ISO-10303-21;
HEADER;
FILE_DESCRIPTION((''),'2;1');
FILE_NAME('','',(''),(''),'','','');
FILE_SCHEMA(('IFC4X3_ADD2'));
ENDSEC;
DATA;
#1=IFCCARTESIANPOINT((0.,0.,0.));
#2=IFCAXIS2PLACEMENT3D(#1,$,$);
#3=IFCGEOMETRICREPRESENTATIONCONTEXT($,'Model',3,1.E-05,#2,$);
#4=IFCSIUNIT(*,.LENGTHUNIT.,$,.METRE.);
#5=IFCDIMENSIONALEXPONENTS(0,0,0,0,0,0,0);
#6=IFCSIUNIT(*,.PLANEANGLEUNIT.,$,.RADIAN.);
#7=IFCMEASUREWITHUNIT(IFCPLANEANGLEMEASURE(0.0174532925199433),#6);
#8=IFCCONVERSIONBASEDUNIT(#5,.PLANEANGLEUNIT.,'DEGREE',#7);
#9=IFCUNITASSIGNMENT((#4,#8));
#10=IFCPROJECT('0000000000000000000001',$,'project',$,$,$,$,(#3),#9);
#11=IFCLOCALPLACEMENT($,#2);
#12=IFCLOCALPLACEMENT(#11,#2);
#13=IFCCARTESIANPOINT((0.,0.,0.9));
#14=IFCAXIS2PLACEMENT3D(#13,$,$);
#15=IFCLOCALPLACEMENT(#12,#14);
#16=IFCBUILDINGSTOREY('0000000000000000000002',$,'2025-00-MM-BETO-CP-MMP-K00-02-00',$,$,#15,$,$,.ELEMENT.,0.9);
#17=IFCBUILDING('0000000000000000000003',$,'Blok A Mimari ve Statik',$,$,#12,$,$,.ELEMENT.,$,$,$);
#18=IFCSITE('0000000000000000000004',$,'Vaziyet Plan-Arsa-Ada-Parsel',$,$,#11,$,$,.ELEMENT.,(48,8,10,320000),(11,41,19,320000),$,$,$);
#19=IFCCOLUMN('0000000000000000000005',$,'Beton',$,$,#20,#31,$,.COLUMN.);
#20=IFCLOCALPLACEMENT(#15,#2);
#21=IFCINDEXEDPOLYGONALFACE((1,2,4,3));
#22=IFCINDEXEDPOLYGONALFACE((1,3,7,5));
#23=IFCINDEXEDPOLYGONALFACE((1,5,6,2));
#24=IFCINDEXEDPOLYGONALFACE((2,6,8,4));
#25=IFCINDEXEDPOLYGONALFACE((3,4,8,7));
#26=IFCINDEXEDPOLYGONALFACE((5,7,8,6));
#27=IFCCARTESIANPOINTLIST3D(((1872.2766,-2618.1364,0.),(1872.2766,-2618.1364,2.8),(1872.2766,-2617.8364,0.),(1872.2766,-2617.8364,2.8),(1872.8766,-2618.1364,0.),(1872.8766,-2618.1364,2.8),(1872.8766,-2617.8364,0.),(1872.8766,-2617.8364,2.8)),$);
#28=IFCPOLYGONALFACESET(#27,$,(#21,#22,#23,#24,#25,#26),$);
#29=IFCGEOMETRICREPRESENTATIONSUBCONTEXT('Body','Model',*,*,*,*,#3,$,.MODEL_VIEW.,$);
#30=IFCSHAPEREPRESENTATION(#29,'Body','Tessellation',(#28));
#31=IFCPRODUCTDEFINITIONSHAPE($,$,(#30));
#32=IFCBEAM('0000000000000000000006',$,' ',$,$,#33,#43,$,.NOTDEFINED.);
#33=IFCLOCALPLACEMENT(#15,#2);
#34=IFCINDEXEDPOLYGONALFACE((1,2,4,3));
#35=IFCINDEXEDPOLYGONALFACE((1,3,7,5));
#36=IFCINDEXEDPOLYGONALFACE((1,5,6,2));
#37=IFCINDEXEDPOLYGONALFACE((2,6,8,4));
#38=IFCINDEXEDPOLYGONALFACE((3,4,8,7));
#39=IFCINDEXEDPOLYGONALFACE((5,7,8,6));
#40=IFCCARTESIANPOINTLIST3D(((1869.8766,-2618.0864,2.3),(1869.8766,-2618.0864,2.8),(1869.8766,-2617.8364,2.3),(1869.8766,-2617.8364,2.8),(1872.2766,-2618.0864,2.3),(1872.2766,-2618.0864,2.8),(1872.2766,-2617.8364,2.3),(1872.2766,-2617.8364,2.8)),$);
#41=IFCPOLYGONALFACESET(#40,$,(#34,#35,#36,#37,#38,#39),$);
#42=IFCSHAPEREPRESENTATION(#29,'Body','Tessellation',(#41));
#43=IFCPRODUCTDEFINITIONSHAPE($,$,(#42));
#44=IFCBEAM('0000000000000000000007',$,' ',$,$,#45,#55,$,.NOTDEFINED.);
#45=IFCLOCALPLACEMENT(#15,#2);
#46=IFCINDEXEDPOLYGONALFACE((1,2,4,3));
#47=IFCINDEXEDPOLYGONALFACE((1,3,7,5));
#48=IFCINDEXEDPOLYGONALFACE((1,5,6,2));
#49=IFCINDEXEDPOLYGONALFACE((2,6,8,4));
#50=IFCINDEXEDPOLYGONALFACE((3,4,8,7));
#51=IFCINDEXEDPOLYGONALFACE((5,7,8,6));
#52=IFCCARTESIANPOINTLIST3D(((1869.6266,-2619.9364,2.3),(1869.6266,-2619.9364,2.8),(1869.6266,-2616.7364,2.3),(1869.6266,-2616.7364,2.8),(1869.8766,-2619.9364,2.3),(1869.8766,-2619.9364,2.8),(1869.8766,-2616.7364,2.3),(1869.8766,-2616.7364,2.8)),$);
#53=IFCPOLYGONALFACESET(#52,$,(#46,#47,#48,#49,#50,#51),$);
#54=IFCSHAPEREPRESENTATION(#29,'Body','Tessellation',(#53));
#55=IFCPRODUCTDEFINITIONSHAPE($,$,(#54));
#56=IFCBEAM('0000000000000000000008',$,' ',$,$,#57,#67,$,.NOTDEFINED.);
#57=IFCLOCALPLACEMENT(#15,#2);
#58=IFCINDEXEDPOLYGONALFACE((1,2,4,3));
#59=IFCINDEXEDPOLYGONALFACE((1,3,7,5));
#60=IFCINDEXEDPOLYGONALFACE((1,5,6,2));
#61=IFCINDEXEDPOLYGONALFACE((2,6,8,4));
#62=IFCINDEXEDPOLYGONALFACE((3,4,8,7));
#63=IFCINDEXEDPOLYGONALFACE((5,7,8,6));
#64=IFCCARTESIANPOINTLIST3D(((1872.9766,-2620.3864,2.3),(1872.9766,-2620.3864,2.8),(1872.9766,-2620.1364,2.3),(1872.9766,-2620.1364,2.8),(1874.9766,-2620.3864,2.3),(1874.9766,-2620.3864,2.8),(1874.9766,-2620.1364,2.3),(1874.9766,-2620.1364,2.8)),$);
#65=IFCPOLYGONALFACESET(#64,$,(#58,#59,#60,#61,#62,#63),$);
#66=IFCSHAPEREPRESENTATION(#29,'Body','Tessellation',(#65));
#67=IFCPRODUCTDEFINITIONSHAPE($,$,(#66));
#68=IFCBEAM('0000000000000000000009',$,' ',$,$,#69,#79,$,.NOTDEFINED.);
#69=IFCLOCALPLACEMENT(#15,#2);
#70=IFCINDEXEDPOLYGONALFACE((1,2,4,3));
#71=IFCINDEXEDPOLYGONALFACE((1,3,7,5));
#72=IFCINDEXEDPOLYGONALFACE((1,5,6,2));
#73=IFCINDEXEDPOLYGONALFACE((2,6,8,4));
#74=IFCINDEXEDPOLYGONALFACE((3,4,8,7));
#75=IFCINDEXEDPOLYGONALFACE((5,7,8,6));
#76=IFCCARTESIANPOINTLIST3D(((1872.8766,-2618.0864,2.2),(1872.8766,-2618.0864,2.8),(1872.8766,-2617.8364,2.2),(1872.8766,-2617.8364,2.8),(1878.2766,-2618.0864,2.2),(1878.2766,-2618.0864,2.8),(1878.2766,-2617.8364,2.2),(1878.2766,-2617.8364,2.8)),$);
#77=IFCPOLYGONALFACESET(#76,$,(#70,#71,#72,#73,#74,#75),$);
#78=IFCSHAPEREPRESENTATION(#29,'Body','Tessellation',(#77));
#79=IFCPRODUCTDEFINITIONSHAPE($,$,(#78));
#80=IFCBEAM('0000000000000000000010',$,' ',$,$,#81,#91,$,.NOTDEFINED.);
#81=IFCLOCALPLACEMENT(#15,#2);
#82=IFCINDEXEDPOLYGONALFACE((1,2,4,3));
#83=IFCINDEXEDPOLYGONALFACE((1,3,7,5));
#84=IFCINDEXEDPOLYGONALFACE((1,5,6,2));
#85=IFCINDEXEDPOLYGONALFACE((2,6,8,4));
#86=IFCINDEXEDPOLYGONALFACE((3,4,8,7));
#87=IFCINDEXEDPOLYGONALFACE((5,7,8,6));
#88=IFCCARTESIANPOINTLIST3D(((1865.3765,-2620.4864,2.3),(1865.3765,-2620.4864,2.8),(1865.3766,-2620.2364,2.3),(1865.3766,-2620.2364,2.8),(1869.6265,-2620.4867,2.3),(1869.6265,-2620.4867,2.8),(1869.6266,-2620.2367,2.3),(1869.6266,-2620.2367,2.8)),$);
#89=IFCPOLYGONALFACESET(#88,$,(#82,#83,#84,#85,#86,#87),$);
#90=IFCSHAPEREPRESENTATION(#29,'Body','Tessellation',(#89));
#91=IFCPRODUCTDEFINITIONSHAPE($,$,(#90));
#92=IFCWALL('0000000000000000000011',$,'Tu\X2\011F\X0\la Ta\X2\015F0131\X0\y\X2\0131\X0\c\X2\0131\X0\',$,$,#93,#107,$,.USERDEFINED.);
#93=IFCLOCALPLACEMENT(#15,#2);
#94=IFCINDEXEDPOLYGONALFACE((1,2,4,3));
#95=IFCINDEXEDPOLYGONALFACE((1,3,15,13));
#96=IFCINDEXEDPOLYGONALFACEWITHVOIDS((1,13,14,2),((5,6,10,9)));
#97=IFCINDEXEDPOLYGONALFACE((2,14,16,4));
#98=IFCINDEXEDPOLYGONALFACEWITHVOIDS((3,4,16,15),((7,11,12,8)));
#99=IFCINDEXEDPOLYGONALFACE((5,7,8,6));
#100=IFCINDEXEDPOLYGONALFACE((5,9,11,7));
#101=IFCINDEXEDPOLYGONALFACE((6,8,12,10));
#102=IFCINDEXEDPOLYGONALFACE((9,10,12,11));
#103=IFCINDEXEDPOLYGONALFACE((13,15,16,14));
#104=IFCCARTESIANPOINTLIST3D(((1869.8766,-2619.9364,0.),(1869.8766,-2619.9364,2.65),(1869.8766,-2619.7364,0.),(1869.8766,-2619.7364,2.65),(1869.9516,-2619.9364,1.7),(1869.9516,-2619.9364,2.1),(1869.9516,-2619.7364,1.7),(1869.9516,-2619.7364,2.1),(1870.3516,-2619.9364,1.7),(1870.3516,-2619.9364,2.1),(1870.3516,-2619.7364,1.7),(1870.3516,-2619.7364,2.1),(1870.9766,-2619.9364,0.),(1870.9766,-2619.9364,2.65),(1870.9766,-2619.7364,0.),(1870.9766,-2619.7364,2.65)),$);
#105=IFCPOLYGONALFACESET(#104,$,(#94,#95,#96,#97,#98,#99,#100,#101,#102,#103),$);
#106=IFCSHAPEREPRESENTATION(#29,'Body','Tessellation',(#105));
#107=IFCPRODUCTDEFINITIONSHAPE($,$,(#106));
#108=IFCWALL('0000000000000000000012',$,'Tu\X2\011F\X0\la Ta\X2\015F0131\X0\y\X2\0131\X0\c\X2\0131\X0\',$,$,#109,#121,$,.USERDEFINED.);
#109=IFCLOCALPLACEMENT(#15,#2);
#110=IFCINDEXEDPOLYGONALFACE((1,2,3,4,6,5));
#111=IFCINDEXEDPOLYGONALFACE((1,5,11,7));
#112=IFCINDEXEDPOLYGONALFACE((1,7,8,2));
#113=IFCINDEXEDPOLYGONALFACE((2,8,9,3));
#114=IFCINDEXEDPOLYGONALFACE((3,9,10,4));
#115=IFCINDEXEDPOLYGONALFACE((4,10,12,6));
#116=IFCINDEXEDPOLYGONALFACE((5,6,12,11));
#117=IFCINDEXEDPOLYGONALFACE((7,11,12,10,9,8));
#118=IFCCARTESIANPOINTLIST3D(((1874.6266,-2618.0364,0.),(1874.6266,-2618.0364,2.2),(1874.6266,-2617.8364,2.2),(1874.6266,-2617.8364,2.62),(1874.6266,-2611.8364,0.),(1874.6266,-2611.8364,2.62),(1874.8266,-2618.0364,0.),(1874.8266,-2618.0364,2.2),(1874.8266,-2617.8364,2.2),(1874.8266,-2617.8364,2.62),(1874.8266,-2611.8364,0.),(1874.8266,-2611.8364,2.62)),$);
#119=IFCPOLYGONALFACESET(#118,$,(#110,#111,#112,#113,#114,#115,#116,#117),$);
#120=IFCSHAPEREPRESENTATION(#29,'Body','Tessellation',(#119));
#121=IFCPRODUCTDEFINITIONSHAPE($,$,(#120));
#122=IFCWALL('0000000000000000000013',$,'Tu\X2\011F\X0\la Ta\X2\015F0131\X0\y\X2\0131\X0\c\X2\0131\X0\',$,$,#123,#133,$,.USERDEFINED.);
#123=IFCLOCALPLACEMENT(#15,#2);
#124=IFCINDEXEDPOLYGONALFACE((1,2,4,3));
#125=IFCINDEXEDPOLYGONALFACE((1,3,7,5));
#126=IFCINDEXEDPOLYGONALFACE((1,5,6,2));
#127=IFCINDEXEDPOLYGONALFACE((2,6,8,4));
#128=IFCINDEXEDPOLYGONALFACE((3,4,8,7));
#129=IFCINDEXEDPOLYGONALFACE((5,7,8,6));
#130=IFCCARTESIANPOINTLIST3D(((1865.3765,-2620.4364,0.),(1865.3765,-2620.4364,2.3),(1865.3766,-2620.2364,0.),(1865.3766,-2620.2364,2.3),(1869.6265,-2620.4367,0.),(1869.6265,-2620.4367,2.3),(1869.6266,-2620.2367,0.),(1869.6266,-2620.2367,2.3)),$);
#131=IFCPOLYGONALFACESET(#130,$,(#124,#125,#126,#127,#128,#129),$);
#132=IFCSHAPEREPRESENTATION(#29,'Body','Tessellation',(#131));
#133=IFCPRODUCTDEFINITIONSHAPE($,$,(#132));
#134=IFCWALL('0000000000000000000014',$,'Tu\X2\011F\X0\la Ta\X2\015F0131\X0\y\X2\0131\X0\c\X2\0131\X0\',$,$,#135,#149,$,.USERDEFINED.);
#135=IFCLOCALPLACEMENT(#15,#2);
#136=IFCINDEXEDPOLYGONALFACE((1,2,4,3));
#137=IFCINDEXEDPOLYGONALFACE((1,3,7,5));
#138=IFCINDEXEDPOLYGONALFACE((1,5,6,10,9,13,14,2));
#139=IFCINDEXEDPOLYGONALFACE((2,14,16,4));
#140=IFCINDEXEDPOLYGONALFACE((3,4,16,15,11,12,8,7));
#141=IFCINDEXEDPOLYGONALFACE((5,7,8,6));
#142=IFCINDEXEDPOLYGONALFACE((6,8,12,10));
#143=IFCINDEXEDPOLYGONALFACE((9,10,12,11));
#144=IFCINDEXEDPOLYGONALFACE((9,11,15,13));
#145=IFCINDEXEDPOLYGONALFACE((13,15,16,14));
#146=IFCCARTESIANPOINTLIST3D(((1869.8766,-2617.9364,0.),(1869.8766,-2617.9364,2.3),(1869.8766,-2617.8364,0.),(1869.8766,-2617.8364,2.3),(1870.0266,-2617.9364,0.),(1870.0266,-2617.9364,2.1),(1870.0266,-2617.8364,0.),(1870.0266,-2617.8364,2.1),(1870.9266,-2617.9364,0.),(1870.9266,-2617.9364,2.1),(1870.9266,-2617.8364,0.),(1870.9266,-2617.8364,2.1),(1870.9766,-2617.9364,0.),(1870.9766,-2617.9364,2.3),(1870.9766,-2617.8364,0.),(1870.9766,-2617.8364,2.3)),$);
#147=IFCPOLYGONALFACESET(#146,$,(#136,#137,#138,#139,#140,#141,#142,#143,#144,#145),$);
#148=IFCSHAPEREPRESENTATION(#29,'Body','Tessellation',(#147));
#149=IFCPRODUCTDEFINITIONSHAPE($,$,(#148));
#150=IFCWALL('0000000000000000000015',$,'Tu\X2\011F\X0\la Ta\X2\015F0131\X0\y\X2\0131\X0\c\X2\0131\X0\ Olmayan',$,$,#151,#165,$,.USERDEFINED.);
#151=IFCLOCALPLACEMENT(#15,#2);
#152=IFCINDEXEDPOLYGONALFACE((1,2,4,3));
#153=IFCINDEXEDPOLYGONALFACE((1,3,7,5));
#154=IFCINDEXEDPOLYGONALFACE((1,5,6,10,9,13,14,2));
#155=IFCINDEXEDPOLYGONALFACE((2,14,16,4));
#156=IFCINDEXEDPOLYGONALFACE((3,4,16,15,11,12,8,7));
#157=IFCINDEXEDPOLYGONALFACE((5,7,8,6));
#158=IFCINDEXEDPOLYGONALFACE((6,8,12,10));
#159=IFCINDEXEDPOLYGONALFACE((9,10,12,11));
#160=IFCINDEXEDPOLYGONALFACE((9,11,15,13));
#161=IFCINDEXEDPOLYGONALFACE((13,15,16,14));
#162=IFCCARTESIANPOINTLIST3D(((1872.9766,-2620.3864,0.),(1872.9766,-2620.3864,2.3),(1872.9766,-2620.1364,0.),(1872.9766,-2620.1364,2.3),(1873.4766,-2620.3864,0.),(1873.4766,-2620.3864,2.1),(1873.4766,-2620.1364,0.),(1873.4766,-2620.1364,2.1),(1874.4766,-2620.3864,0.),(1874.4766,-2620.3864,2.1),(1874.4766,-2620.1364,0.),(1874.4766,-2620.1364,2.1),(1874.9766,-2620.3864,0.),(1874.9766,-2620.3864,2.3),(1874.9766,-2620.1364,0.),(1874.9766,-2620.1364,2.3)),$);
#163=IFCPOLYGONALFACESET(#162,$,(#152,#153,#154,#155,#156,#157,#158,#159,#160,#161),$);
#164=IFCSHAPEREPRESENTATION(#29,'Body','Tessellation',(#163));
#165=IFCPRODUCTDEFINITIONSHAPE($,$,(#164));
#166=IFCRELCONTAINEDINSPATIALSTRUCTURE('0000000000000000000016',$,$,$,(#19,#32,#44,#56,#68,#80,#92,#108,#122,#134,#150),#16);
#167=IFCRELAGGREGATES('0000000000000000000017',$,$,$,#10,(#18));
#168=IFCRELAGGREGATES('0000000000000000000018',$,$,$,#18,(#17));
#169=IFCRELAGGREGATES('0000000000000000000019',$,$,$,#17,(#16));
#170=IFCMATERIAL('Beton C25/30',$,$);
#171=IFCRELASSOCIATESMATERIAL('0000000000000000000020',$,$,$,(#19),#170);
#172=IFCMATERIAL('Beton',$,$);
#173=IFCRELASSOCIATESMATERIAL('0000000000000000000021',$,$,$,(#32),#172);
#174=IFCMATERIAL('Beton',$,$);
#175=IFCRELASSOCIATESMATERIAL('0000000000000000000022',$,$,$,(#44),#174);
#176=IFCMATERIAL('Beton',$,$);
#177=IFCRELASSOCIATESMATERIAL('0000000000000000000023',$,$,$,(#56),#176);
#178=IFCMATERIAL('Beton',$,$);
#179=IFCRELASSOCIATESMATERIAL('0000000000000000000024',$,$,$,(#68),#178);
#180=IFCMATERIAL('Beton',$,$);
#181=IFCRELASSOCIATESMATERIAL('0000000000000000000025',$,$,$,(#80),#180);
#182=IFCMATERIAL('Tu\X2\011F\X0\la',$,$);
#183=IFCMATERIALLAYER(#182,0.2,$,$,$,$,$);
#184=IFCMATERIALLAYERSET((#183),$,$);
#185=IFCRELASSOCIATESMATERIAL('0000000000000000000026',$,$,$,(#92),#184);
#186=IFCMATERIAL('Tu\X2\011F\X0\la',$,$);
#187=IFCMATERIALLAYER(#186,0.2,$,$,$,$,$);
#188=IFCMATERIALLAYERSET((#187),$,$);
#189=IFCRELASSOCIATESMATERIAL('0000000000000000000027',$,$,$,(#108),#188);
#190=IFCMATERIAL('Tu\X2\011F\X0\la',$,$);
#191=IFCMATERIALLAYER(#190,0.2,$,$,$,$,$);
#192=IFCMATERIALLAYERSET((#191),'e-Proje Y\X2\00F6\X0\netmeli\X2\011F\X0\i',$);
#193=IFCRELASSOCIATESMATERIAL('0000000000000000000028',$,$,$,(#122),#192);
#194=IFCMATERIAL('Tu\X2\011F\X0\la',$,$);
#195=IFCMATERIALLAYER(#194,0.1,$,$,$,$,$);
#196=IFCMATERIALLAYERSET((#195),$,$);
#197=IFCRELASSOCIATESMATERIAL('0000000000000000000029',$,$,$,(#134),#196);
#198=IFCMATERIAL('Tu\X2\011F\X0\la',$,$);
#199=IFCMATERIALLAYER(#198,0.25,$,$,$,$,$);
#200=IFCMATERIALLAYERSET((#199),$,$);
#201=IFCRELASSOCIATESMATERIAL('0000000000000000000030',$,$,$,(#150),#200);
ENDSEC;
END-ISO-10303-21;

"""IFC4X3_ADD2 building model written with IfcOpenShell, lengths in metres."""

from ifc_helpers import new_model, entity, si_unit, converted_unit, frame, frame_2d, origin, origin_with_axes, place, context, subcontext, project, spatial, polyline, rectangle, outline, extrude, clip, bounded_halfspace, material, layer, layer_set, layer_usage, element, save


model = new_model("IFC4X3_ADD2")

# Units and contexts
model_context = context("Model", 3, precision=1e-05, world=origin())
body_context = subcontext(model_context, "Body", "Model", "MODEL_VIEW")
ifc_project = project(units=[si_unit("LENGTHUNIT", "METRE"), converted_unit("PLANEANGLEUNIT", "DEGREE", entity("IfcPlaneAngleMeasure", 0.0174532925199433), si_unit("PLANEANGLEUNIT", "RADIAN"), dimensions=[0, 0, 0, 0, 0, 0, 0])], contexts=[model_context])

# Site, building, storey
site_placement = place(None, origin())
site = spatial("IfcSite", under=ifc_project, at=site_placement, Name="Vaziyet Plan-Arsa-Ada-Parsel", CompositionType="ELEMENT", RefLatitude=(48, 8, 10, 320000), RefLongitude=(11, 41, 19, 320000))
building_placement = place(site_placement, origin())
building = spatial("IfcBuilding", under=site, at=building_placement, Name="Blok A Mimari ve Statik", CompositionType="ELEMENT")
storey_placement = place(building_placement, frame((0.0, 0.0, 0.9)))
storey = spatial("IfcBuildingStorey", under=building, at=storey_placement, Name="2025-00-MM-BETO-CP-MMP-K00-02-00", CompositionType="ELEMENT", Elevation=0.9)

# Column
ifc_material_1 = material(Name="Beton C25/30")
column_placement = place(storey_placement, frame((1872.2766, -2618.1364, 0.0)))
element("IfcColumn", 1, at=column_placement, inside=storey, material=ifc_material_1, Name="Beton", PredefinedType="COLUMN", context=body_context, shape_type="SweptSolid", body=[
    extrude(outline(polyline([(0.0, 0.0), (0.6, 0.0), (0.6, 0.3), (0.0, 0.3), (0.0, 0.0)])), origin_with_axes(), (0.0, 0.0, 1.0), 2.8),
])

# Beams
ifc_material_2 = material(Name="Beton")
beam_1_placement = place(storey_placement, frame((1869.8766, -2618.0864, 2.3)))
element("IfcBeam", 2, at=beam_1_placement, inside=storey, material=ifc_material_2, Name=" ", PredefinedType="NOTDEFINED", context=body_context, shape_type="SweptSolid", body=[
    extrude(rectangle(XDim=0.25, YDim=0.5, at=frame_2d((0.125, 0.25), x_axis=(1.0, 0.0))), frame((0.0, 0.0, 0.0), z_axis=(1.0, 0.0, 0.0), x_axis=(0.0, 1.0, 0.0)), (0.0, 0.0, 1.0), 2.4),
])
ifc_material_3 = material(Name="Beton")
beam_2_placement = place(storey_placement, frame((1869.8766, -2619.9364, 2.3), z_axis=(0.0, 0.0, 1.0), x_axis=(0.0, 1.0, 0.0)))
element("IfcBeam", 3, at=beam_2_placement, inside=storey, material=ifc_material_3, Name=" ", PredefinedType="NOTDEFINED", context=body_context, shape_type="SweptSolid", body=[
    extrude(rectangle(XDim=0.25, YDim=0.5, at=frame_2d((0.125, 0.25), x_axis=(1.0, 0.0))), frame((0.0, 0.0, 0.0), z_axis=(1.0, 0.0, 0.0), x_axis=(0.0, 1.0, 0.0)), (0.0, 0.0, 1.0), 3.2),
])
ifc_material_4 = material(Name="Beton")
beam_3_placement = place(storey_placement, frame((1874.9766, -2620.1364, 2.3), z_axis=(0.0, 0.0, 1.0), x_axis=(-1.0, 0.0, 0.0)))
element("IfcBeam", 4, at=beam_3_placement, inside=storey, material=ifc_material_4, Name=" ", PredefinedType="NOTDEFINED", context=body_context, shape_type="SweptSolid", body=[
    extrude(rectangle(XDim=0.25, YDim=0.5, at=frame_2d((0.125, 0.25), x_axis=(1.0, 0.0))), frame((0.0, 0.0, 0.0), z_axis=(1.0, 0.0, 0.0), x_axis=(0.0, 1.0, 0.0)), (0.0, 0.0, 1.0), 2.0),
])
ifc_material_5 = material(Name="Beton")
beam_4_placement = place(storey_placement, frame((1872.8766, -2618.0864, 2.2)))
element("IfcBeam", 5, at=beam_4_placement, inside=storey, material=ifc_material_5, Name=" ", PredefinedType="NOTDEFINED", context=body_context, shape_type="SweptSolid", body=[
    extrude(rectangle(XDim=0.25, YDim=0.6, at=frame_2d((0.125, 0.3), x_axis=(1.0, 0.0))), frame((0.0, 0.0, 0.0), z_axis=(1.0, 0.0, 0.0), x_axis=(0.0, 1.0, 0.0)), (0.0, 0.0, 1.0), 5.4),
])
ifc_material_6 = material(Name="Beton")
beam_5_placement = place(storey_placement, frame((1869.6266, -2620.2367, 2.3), z_axis=(0.0, 0.0, 1.0), x_axis=(-1.0, 0.000072, 0.0)))
element("IfcBeam", 6, at=beam_5_placement, inside=storey, material=ifc_material_6, Name=" ", PredefinedType="NOTDEFINED", context=body_context, shape_type="SweptSolid", body=[
    extrude(rectangle(XDim=0.25, YDim=0.5, at=frame_2d((0.125, 0.25), x_axis=(1.0, 0.0))), frame((0.0, 0.0, 0.0), z_axis=(1.0, 0.0, 0.0), x_axis=(0.0, 1.0, 0.0)), (0.0, 0.0, 1.0), 4.25),
])

# Wall, opening
ifc_material_7 = material(Name="Tuğla")
ifc_layer_1 = layer(ifc_material_7, 0.2)
ifc_layer_set_1 = layer_set([ifc_layer_1])
ifc_layer_usage_1 = layer_usage(ifc_layer_set_1, "AXIS2", "POSITIVE", 0.0)
wall_1_placement = place(storey_placement, frame((1870.9766, -2619.7364, 0.0), z_axis=(0.0, 0.0, 1.0), x_axis=(-1.0, 0.0, 0.0)))
wall_1 = element("IfcWall", 7, at=wall_1_placement, inside=storey, material=ifc_layer_usage_1, Name="Tuğla Taşıyıcı", PredefinedType="USERDEFINED", context=body_context, shape_type="SweptSolid", body=[
    extrude(rectangle(XDim=1.1, YDim=0.2, at=frame_2d((0.55, 0.1), x_axis=(1.0, 0.0))), origin_with_axes(), (0.0, 0.0, 1.0), 2.65),
])
opening_1_placement = place(wall_1_placement, frame((0.625, 0.0, 1.7), z_axis=(0.0, 1.0, 0.0), x_axis=(0.0, 0.0, 1.0)))
element("IfcOpeningElement", 8, at=opening_1_placement, cuts=wall_1, PredefinedType="OPENING", context=body_context, shape_type="SweptSolid", body=[
    extrude(outline(polyline([(0.4, 0.4), (0.4, 0.0), (0.0, 0.0), (0.0, 0.4), (0.4, 0.4)])), origin_with_axes(), (0.0, 0.0, 1.0), 0.2),
])

# Walls
ifc_material_8 = material(Name="Tuğla")
ifc_layer_2 = layer(ifc_material_8, 0.2)
ifc_layer_set_2 = layer_set([ifc_layer_2])
ifc_layer_usage_2 = layer_usage(ifc_layer_set_2, "AXIS2", "POSITIVE", 0.0)
wall_2_placement = place(storey_placement, frame((1874.8266, -2618.0364, 0.0), z_axis=(0.0, 0.0, 1.0), x_axis=(0.0, 1.0, 0.0)))
element("IfcWall", 9, at=wall_2_placement, inside=storey, material=ifc_layer_usage_2, Name="Tuğla Taşıyıcı", PredefinedType="USERDEFINED", context=body_context, shape_type="Clipping", body=[
    clip(extrude(rectangle(XDim=6.2, YDim=0.2, at=frame_2d((3.1, 0.1), x_axis=(1.0, 0.0))), origin_with_axes(), (0.0, 0.0, 1.0), 2.62), bounded_halfspace(frame((0.1, 0.1, 2.2), z_axis=(0.0, 0.0, -1.0), x_axis=(0.0, -1.0, 0.0)), True, origin_with_axes(), polyline([(0.0, 0.2), (0.0, 0.0), (0.2, 0.0), (0.2, 0.2), (0.0, 0.2)]))),
])
ifc_material_9 = material(Name="Tuğla")
ifc_layer_3 = layer(ifc_material_9, 0.2)
ifc_layer_set_3 = layer_set([ifc_layer_3], Name="e-Proje Yönetmeliği")
ifc_layer_usage_3 = layer_usage(ifc_layer_set_3, "AXIS2", "POSITIVE", 0.0)
wall_3_placement = place(storey_placement, frame((1869.6266, -2620.2367, 0.0), z_axis=(0.0, 0.0, 1.0), x_axis=(-1.0, 0.000072, 0.0)))
element("IfcWall", 10, at=wall_3_placement, inside=storey, material=ifc_layer_usage_3, Name="Tuğla Taşıyıcı", PredefinedType="USERDEFINED", context=body_context, shape_type="SweptSolid", body=[
    extrude(rectangle(XDim=4.25, YDim=0.2, at=frame_2d((2.125, 0.1), x_axis=(1.0, 0.0))), origin_with_axes(), (0.0, 0.0, 1.0), 2.3),
])

# Walls, openings
ifc_material_10 = material(Name="Tuğla")
ifc_layer_4 = layer(ifc_material_10, 0.1)
ifc_layer_set_4 = layer_set([ifc_layer_4])
ifc_layer_usage_4 = layer_usage(ifc_layer_set_4, "AXIS2", "POSITIVE", 0.0)
wall_4_placement = place(storey_placement, frame((1870.9766, -2617.8364, 0.0), z_axis=(0.0, 0.0, 1.0), x_axis=(-1.0, 0.0, 0.0)))
wall_4 = element("IfcWall", 11, at=wall_4_placement, inside=storey, material=ifc_layer_usage_4, Name="Tuğla Taşıyıcı", PredefinedType="USERDEFINED", context=body_context, shape_type="SweptSolid", body=[
    extrude(rectangle(XDim=1.1, YDim=0.1, at=frame_2d((0.55, 0.05), x_axis=(1.0, 0.0))), origin_with_axes(), (0.0, 0.0, 1.0), 2.3),
])
opening_2_placement = place(wall_4_placement, frame((0.05, 0.0, 0.0), z_axis=(0.0, 1.0, 0.0), x_axis=(0.0, 0.0, 1.0)))
element("IfcOpeningElement", 12, at=opening_2_placement, cuts=wall_4, PredefinedType="OPENING", context=body_context, shape_type="SweptSolid", body=[
    extrude(outline(polyline([(2.1, 0.9), (2.1, 0.0), (0.0, 0.0), (0.0, 0.9), (2.1, 0.9)])), origin_with_axes(), (0.0, 0.0, 1.0), 0.1),
])
ifc_material_11 = material(Name="Tuğla")
ifc_layer_5 = layer(ifc_material_11, 0.25)
ifc_layer_set_5 = layer_set([ifc_layer_5])
ifc_layer_usage_5 = layer_usage(ifc_layer_set_5, "AXIS2", "POSITIVE", 0.0)
wall_5_placement = place(storey_placement, frame((1874.9766, -2620.1364, 0.0), z_axis=(0.0, 0.0, 1.0), x_axis=(-1.0, 0.0, 0.0)))
wall_5 = element("IfcWall", 13, at=wall_5_placement, inside=storey, material=ifc_layer_usage_5, Name="Tuğla Taşıyıcı Olmayan", PredefinedType="USERDEFINED", context=body_context, shape_type="SweptSolid", body=[
    extrude(rectangle(XDim=2.0, YDim=0.25, at=frame_2d((1.0, 0.125), x_axis=(1.0, 0.0))), origin_with_axes(), (0.0, 0.0, 1.0), 2.3),
])
opening_3_placement = place(wall_5_placement, frame((1.5, 0.25, 0.0), z_axis=(0.0, -1.0, 0.0), x_axis=(0.0, 0.0, 1.0)))
element("IfcOpeningElement", 14, at=opening_3_placement, cuts=wall_5, PredefinedType="OPENING", context=body_context, shape_type="SweptSolid", body=[
    extrude(outline(polyline([(2.1, 1.0), (2.1, 0.0), (0.0, 0.0), (0.0, 1.0), (2.1, 1.0)])), origin_with_axes(), (0.0, 0.0, 1.0), 0.25),
])

save(model, "model.ifc")
